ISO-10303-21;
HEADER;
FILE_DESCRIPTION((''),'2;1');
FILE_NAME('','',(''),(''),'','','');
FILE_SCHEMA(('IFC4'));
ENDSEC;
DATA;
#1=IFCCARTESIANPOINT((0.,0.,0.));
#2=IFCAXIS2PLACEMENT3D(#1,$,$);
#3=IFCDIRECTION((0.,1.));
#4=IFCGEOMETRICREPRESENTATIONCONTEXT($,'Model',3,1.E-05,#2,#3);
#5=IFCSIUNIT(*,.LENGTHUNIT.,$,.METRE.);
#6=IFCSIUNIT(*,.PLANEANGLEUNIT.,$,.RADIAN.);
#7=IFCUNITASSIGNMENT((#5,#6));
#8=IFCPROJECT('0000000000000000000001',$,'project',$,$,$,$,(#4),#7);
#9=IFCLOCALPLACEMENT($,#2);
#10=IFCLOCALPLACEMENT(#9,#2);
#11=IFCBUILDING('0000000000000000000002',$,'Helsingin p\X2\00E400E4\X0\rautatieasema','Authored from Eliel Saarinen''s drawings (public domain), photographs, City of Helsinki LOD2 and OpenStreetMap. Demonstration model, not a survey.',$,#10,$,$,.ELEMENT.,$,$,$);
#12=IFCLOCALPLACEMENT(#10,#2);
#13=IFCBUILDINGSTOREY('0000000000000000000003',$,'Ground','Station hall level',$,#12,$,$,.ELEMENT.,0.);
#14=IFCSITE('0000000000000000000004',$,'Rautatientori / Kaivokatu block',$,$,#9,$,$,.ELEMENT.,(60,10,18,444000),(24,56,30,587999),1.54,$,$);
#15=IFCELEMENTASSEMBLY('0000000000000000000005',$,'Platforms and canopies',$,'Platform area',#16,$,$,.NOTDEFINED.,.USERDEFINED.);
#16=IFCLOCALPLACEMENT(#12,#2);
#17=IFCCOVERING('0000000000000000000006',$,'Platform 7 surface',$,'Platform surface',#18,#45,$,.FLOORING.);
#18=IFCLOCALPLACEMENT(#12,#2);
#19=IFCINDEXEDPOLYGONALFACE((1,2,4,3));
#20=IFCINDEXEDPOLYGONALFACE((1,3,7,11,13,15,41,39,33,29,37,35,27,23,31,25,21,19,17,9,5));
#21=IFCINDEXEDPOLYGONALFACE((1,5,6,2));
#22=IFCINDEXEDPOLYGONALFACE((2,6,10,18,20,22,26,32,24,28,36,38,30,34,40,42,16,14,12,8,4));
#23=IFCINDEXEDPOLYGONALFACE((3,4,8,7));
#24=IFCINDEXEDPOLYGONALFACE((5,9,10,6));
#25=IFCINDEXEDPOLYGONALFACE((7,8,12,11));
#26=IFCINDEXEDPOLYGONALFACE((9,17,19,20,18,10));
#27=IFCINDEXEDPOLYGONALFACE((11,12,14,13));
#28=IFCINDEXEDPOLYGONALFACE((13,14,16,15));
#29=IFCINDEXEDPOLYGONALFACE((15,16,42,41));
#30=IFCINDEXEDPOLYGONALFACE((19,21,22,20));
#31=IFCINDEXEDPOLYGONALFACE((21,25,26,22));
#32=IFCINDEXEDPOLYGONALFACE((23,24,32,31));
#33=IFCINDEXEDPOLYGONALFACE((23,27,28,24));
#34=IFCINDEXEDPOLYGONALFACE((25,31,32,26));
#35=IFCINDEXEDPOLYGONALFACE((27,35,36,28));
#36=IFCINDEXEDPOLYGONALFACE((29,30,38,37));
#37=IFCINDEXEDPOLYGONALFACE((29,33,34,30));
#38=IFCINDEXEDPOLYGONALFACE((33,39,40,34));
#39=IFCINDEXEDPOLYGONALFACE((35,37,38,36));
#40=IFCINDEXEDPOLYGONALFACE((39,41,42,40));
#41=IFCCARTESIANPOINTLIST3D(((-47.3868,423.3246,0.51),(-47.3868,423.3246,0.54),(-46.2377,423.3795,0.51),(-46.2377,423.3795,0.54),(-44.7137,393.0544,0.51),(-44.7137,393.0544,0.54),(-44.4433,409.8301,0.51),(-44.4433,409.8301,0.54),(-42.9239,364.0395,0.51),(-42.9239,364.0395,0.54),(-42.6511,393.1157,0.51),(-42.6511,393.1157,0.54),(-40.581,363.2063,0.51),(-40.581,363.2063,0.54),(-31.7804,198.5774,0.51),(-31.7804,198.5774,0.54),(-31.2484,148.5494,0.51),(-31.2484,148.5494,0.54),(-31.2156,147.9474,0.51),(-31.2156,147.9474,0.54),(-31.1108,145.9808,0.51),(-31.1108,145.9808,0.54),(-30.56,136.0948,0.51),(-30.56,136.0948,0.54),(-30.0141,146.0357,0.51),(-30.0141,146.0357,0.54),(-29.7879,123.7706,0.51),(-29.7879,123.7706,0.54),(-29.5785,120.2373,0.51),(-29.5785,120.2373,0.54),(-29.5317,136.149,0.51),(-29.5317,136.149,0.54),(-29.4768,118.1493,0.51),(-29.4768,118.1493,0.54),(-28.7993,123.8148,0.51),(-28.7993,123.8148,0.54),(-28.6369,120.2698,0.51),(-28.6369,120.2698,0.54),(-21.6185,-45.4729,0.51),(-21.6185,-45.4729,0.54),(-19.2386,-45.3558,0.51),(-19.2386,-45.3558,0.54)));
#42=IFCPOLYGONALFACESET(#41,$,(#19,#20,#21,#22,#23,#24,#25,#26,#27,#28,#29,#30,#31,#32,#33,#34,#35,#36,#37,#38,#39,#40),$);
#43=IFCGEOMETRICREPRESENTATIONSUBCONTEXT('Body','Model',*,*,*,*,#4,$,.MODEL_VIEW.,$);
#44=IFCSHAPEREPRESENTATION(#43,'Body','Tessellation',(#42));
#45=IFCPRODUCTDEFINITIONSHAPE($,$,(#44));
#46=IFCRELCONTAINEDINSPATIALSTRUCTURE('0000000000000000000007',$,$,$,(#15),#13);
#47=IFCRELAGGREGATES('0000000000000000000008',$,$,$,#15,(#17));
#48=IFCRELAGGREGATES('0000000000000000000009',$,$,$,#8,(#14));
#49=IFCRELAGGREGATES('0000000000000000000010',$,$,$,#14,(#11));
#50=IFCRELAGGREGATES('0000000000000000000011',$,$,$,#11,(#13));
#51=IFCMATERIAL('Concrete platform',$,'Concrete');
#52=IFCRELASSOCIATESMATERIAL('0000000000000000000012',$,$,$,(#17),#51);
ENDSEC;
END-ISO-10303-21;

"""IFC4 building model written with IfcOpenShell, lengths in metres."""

from ifc_helpers import new_model, si_unit, direction, frame, origin, place, context, subcontext, project, spatial, polyline, outline, extrude, material, element, aggregate, save


model = new_model("IFC4")

# Units and contexts
model_context = context("Model", 3, precision=1e-05, world=origin(), true_north=direction((0.0, 1.0)))
body_context = subcontext(model_context, "Body", "Model", "MODEL_VIEW")
ifc_project = project(units=[si_unit("LENGTHUNIT", "METRE"), si_unit("PLANEANGLEUNIT", "RADIAN")], contexts=[model_context])

# Site, building, storey
site_placement = place(None, origin())
site = spatial("IfcSite", under=ifc_project, at=site_placement, Name="Rautatientori / Kaivokatu block", CompositionType="ELEMENT", RefLatitude=(60, 10, 18, 444000), RefLongitude=(24, 56, 30, 587999), RefElevation=1.54)
building_placement = place(site_placement, origin())
building = spatial("IfcBuilding", under=site, at=building_placement, Name="Helsingin päärautatieasema", Description="Authored from Eliel Saarinen's drawings (public domain), photographs, City of Helsinki LOD2 and OpenStreetMap. Demonstration model, not a survey.", CompositionType="ELEMENT")
storey_placement = place(building_placement, origin())
storey = spatial("IfcBuildingStorey", under=building, at=storey_placement, Name="Ground", Description="Station hall level", CompositionType="ELEMENT", Elevation=0.0)

# Element assembly, covering
assembly_placement = place(building_placement, origin())
assembly = element("IfcElementAssembly", 1, at=assembly_placement, inside=storey, Name="Platforms and canopies", ObjectType="Platform area", AssemblyPlace="NOTDEFINED", PredefinedType="USERDEFINED")
ifc_material_1 = material(Name="Concrete platform", Category="Concrete")
covering_1_placement = place(building_placement, origin())
covering_1 = element("IfcCovering", 2, at=covering_1_placement, material=ifc_material_1, Name="Platform 7 surface", ObjectType="Platform surface", PredefinedType="FLOORING", context=body_context, shape_type="SweptSolid", body=[
    extrude(outline(polyline([(-19.2386, -45.3558), (-21.6185, -45.4729), (-29.4768, 118.1493), (-29.5785, 120.2373), (-28.6369, 120.2698), (-28.7993, 123.8148), (-29.7879, 123.7706), (-30.56, 136.0948), (-29.5317, 136.149), (-30.0141, 146.0357), (-31.1108, 145.9808), (-31.2156, 147.9474), (-31.2484, 148.5494), (-42.9239, 364.0395), (-44.7137, 393.0544), (-47.3868, 423.3246), (-46.2377, 423.3795), (-44.4433, 409.8301), (-42.6511, 393.1157), (-40.581, 363.2063), (-31.7804, 198.5774), (-19.2386, -45.3558)])), frame((0.0, 0.0, 0.51)), (0.0, 0.0, 1.0), 0.03),
])
aggregate(assembly, [covering_1])

save(model, "model.ifc")
